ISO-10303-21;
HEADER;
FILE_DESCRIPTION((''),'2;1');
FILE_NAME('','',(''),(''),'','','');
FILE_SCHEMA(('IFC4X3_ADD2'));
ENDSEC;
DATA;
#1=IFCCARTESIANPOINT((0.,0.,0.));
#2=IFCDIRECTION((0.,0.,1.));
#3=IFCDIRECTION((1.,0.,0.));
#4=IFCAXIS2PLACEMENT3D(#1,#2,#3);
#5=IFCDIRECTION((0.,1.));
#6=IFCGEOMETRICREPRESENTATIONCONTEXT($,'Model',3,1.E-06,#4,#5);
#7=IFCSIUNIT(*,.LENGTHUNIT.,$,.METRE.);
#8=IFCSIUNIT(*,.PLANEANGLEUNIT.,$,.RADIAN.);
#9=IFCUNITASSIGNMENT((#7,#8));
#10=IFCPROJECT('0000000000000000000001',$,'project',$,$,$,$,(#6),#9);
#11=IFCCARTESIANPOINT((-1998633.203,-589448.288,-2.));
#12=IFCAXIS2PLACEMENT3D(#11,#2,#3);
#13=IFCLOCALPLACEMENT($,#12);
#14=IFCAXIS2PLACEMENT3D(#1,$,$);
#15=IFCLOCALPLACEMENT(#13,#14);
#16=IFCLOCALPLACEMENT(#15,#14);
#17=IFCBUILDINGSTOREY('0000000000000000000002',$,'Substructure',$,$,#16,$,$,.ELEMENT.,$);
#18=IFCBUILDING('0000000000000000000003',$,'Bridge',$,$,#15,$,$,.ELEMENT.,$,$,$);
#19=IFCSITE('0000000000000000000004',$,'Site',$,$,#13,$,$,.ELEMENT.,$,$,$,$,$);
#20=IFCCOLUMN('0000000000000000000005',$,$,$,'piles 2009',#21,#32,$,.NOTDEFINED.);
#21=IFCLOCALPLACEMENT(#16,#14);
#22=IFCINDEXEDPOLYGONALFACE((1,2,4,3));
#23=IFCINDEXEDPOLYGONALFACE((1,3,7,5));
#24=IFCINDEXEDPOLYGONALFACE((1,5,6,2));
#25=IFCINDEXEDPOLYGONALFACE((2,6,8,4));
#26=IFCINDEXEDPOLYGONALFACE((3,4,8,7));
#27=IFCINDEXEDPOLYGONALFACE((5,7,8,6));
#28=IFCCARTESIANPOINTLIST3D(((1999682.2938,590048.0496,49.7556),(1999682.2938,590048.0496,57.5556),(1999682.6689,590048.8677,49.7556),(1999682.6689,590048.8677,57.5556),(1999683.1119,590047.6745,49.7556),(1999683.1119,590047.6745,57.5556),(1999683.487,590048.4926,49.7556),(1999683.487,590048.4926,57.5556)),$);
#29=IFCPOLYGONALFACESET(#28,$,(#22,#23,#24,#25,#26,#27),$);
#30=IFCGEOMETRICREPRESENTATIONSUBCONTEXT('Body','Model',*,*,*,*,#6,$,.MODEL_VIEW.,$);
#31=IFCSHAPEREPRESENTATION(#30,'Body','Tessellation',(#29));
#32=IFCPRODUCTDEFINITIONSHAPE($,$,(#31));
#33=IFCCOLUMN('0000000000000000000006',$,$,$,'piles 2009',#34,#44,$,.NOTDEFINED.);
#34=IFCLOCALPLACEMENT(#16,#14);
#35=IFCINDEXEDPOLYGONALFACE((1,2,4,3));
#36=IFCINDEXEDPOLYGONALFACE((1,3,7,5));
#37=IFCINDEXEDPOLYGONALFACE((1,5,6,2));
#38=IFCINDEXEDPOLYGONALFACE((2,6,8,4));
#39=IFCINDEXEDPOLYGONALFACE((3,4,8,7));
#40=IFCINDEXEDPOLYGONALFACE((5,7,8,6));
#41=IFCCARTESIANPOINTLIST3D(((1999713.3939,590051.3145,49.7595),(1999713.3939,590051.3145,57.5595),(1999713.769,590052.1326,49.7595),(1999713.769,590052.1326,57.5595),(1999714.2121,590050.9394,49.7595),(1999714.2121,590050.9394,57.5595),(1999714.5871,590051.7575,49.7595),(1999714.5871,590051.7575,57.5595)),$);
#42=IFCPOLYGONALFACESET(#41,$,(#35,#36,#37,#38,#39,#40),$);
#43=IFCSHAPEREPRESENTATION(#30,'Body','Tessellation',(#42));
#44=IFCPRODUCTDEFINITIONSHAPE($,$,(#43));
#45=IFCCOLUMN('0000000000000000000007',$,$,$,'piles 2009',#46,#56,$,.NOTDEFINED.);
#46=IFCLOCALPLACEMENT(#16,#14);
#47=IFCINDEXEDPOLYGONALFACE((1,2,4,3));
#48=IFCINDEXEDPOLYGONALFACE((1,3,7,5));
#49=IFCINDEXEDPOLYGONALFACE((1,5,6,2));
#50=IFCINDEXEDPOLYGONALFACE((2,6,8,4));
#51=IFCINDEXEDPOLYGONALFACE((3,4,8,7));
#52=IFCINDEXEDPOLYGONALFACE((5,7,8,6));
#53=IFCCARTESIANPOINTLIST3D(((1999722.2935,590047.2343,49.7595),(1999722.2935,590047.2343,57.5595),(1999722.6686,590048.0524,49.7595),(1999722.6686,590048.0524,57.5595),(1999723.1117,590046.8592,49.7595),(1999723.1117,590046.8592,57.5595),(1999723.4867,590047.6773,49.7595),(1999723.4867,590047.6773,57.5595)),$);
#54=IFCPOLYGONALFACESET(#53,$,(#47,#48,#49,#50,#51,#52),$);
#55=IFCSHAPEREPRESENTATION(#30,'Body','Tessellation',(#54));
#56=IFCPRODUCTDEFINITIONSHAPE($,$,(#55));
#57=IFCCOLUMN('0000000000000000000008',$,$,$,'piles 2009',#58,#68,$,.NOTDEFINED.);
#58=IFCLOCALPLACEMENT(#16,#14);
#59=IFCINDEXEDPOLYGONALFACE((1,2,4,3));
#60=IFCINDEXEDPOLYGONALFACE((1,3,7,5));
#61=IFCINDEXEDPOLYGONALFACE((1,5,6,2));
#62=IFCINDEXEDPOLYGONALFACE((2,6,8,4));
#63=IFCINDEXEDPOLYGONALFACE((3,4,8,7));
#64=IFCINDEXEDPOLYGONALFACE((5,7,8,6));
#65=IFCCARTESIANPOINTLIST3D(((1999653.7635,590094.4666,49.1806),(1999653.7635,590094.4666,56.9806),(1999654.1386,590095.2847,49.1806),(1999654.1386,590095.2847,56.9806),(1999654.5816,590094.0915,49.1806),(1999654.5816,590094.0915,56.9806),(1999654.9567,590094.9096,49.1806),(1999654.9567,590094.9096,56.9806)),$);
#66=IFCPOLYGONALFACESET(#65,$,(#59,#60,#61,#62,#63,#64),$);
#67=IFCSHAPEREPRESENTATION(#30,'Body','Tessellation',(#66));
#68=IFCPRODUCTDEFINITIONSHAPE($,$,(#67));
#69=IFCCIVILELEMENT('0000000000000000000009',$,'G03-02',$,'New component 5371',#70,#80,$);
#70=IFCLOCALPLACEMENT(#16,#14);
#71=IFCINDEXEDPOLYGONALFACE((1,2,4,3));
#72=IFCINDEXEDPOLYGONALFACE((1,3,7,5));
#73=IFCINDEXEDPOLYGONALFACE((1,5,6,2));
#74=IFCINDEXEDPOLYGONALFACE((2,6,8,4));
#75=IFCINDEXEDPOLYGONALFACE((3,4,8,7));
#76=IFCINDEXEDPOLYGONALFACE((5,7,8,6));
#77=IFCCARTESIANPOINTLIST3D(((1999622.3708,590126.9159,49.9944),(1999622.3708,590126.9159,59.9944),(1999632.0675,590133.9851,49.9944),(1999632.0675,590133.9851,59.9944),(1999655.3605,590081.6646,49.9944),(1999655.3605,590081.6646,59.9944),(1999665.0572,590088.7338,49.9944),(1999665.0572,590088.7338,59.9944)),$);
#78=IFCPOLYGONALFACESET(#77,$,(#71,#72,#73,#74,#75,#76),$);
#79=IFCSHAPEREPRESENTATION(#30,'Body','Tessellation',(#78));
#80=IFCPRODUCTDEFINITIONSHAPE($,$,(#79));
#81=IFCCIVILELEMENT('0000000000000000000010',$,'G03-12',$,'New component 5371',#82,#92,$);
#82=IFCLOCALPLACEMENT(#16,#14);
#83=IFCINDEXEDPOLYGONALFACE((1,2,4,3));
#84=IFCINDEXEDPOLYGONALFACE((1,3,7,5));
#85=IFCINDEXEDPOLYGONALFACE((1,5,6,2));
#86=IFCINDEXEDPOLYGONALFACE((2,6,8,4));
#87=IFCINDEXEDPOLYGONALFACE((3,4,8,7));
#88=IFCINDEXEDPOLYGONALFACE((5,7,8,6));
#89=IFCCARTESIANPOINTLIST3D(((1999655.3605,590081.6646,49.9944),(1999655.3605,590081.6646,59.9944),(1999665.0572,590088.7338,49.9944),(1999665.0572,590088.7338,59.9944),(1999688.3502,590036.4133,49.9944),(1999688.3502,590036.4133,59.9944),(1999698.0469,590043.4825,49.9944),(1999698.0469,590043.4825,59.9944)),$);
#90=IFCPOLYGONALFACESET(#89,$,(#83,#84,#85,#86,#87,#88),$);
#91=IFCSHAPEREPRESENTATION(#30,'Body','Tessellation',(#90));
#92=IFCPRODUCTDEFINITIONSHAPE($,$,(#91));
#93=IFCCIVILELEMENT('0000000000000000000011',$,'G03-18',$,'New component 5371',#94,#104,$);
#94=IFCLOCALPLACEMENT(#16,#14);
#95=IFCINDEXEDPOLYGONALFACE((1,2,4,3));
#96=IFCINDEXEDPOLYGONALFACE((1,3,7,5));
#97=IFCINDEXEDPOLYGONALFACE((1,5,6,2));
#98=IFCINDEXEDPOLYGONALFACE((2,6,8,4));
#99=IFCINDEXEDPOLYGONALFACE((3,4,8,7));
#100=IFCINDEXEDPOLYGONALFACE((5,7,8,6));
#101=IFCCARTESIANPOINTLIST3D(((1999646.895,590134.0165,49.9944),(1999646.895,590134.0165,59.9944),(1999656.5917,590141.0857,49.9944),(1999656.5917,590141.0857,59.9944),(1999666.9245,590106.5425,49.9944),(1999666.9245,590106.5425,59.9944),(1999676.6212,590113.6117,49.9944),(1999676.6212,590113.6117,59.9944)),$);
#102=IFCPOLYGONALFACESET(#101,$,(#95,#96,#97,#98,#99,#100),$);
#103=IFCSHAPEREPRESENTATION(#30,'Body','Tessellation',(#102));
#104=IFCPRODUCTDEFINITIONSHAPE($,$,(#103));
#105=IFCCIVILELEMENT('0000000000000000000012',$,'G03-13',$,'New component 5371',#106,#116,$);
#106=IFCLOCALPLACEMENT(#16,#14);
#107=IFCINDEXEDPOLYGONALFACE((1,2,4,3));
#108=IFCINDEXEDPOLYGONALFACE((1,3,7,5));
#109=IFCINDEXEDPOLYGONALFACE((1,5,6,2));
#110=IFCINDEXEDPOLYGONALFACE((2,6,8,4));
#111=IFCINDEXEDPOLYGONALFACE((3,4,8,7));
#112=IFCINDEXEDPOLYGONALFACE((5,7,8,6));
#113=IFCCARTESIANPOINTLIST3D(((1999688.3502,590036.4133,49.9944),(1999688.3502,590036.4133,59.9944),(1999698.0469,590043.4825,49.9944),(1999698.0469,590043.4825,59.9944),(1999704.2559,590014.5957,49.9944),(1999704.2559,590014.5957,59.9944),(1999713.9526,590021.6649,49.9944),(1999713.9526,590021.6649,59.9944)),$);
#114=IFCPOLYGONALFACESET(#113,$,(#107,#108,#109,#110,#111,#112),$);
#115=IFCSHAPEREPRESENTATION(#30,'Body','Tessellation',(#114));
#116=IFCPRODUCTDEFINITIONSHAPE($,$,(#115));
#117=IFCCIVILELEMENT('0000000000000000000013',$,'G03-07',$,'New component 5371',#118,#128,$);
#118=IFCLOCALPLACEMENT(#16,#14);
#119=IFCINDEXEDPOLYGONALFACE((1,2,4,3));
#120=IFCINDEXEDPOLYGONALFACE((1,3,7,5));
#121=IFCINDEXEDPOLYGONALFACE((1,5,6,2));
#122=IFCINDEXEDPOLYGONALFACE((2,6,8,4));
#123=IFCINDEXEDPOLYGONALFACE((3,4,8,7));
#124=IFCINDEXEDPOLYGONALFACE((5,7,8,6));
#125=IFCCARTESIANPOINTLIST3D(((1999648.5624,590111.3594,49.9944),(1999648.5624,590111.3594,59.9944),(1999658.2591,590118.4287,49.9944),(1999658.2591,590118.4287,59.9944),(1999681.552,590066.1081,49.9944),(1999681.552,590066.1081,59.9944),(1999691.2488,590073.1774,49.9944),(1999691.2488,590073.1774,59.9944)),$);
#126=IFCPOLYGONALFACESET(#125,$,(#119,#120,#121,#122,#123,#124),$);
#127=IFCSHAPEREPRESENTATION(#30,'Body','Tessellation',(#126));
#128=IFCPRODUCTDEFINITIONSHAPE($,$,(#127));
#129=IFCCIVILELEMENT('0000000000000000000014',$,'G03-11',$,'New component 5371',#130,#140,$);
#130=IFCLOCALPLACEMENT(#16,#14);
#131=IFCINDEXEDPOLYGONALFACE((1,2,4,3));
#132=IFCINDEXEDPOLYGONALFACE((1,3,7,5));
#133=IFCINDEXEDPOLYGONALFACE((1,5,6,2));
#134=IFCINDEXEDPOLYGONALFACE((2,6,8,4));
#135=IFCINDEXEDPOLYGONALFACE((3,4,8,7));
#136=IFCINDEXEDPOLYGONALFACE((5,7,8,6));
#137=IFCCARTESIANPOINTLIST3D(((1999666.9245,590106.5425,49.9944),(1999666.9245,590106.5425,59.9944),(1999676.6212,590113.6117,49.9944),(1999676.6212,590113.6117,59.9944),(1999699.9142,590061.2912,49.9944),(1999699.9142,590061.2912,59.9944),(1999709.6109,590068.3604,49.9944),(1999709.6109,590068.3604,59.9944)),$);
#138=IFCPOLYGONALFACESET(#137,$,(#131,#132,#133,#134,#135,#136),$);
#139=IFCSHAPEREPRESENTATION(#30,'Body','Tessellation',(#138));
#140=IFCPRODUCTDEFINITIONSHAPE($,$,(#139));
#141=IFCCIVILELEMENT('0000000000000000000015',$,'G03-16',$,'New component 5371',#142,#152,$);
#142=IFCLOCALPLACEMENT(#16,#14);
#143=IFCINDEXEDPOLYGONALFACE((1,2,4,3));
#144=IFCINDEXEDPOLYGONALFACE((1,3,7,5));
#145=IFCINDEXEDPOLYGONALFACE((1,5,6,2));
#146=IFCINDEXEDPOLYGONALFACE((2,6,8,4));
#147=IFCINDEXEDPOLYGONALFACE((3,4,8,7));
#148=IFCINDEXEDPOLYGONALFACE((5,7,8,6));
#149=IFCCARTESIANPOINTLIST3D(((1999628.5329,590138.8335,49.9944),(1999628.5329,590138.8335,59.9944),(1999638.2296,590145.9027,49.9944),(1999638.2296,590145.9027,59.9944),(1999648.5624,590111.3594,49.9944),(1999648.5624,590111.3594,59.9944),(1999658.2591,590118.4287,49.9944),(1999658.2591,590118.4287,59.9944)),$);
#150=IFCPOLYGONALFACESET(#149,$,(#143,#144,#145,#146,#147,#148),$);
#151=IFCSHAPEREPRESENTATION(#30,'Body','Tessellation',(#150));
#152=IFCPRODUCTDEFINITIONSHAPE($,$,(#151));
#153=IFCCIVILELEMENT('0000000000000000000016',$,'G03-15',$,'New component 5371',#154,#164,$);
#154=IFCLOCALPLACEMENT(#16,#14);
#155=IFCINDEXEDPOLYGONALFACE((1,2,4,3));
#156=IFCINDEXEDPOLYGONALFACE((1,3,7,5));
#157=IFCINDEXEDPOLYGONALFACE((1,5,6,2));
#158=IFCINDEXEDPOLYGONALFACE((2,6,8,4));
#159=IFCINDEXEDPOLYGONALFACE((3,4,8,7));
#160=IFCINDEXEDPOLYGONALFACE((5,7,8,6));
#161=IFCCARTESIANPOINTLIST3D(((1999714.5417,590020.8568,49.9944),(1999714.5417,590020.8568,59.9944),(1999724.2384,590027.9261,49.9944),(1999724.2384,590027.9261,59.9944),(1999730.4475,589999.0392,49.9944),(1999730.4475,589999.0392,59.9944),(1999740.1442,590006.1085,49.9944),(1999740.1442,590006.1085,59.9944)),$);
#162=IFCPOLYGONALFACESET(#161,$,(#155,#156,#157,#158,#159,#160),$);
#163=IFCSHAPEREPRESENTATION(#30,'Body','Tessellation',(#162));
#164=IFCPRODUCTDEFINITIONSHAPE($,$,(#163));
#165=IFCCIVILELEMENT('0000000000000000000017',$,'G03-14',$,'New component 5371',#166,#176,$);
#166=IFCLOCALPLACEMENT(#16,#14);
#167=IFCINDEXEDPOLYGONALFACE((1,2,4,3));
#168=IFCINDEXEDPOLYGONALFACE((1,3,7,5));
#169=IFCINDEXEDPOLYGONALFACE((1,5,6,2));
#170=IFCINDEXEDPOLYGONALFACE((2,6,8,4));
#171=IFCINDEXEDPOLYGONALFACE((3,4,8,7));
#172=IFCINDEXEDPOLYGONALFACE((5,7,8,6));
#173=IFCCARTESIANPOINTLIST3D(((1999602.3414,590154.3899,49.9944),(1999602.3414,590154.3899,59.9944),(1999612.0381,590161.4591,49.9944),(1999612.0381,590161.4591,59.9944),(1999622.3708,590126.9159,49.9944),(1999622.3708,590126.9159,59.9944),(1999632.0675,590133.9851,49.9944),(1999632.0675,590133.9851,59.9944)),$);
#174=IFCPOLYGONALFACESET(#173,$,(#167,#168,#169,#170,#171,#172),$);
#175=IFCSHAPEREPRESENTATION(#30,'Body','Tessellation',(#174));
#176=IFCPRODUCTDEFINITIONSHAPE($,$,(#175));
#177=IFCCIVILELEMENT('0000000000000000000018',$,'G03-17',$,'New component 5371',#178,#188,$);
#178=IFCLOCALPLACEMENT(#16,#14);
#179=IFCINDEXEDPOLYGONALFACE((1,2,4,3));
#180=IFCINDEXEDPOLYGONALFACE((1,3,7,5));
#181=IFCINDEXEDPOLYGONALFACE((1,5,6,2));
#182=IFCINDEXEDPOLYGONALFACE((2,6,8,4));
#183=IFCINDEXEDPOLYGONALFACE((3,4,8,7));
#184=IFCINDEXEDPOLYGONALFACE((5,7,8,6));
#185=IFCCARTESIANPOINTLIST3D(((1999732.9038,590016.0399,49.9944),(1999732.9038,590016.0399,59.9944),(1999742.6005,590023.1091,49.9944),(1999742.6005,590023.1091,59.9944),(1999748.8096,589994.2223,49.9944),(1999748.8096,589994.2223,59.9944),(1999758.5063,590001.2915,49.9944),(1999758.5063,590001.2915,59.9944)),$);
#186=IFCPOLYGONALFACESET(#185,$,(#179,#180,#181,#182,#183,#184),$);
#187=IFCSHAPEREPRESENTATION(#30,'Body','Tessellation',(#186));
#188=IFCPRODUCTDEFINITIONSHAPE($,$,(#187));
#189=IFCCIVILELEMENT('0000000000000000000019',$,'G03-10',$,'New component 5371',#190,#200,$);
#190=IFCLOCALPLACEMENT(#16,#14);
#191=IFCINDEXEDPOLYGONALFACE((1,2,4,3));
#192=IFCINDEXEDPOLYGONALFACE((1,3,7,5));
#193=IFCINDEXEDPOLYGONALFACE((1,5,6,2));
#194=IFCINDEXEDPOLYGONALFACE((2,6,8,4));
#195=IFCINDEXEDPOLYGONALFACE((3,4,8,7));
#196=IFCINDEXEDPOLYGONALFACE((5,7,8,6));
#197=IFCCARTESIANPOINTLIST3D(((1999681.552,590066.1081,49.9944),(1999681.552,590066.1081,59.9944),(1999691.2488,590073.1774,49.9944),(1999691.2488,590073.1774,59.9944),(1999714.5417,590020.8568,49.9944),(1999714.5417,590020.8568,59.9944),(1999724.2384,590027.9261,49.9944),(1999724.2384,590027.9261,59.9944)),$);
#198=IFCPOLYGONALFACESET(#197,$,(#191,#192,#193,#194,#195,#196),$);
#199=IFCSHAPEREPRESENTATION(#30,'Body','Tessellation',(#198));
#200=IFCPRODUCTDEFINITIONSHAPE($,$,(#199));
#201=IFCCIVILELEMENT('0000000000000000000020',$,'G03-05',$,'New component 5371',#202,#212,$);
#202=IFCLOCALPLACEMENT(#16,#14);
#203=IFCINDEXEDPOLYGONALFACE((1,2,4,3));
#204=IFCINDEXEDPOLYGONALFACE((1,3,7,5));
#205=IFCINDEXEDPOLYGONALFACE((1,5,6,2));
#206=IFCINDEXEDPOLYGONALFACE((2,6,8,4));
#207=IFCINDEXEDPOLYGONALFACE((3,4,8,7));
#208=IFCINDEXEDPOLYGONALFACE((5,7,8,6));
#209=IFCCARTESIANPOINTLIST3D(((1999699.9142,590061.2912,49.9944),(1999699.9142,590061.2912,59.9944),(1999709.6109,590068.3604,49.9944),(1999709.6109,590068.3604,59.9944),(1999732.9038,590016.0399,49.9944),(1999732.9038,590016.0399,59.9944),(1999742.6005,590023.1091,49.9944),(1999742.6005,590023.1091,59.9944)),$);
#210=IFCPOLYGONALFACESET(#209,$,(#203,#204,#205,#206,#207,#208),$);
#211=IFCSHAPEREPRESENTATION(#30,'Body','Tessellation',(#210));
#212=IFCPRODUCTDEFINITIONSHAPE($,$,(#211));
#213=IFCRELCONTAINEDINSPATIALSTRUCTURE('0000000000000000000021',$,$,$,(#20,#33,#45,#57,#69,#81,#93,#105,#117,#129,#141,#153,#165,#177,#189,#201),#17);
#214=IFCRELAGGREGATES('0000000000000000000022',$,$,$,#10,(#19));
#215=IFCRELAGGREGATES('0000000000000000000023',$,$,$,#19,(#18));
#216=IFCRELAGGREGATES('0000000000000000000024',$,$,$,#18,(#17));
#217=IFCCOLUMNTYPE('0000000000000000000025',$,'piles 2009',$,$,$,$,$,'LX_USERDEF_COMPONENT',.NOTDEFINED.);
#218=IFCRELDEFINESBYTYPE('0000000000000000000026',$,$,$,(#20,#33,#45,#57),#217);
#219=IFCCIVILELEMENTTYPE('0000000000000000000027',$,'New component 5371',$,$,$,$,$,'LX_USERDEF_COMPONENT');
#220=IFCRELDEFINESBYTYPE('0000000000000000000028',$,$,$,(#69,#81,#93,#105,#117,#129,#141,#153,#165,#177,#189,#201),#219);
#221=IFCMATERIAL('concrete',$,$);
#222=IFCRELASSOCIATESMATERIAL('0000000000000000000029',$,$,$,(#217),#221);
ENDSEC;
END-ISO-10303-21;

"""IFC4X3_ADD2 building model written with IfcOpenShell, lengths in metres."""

from ifc_helpers import new_model, si_unit, direction, frame, frame_2d, origin, origin_with_axes, place, context, subcontext, project, spatial, rectangle, extrude, material, type_object, element, save


model = new_model("IFC4X3_ADD2")

# Units and contexts
model_context = context("Model", 3, precision=1e-06, world=origin_with_axes(), true_north=direction((0.0, 1.0)))
body_context = subcontext(model_context, "Body", "Model", "MODEL_VIEW")
ifc_project = project(units=[si_unit("LENGTHUNIT", "METRE"), si_unit("PLANEANGLEUNIT", "RADIAN")], contexts=[model_context])

# Site, building, storey
site_placement = place(None, frame((-1998633.203, -589448.288, -2.0), z_axis=(0.0, 0.0, 1.0), x_axis=(1.0, 0.0, 0.0)))
site = spatial("IfcSite", under=ifc_project, at=site_placement, Name="Site", CompositionType="ELEMENT")
building_placement = place(site_placement, origin())
building = spatial("IfcBuilding", under=site, at=building_placement, Name="Bridge", CompositionType="ELEMENT")
storey_placement = place(building_placement, origin())
storey = spatial("IfcBuildingStorey", under=building, at=storey_placement, Name="Substructure", CompositionType="ELEMENT")

# Columns
ifc_material = material(Name="concrete")
column_type = type_object("IfcColumnType", Name="piles 2009", ElementType="LX_USERDEF_COMPONENT", PredefinedType="NOTDEFINED", material=ifc_material)
for number, where, z_axis, x_axis in (
    (1, (1999683.1119, 590047.6745, 49.7556), (0.0, 0.0, 1.0), (0.416757, 0.909018, 0.0)),
    (2, (1999714.2121, 590050.9394, 49.7595), (0.0, 0.0, 1.0), (0.416757, 0.909018, 0.0)),
    (3, (1999723.1117, 590046.8592, 49.7595), (0.0, 0.0, 1.0), (0.416757, 0.909018, 0.0)),
    (4, (1999654.5816, 590094.0915, 49.1806), (0.0, 0.0, 1.0), (0.416757, 0.909018, 0.0)),
):
    element("IfcColumn", number, at=place(storey_placement, frame(where, z_axis=z_axis, x_axis=x_axis)), inside=storey, type_object=column_type, ObjectType="piles 2009", PredefinedType="NOTDEFINED", context=body_context, shape_type="SweptSolid", body=[
        extrude(rectangle(XDim=0.9, YDim=0.9, at=frame_2d((0.45, 0.45), x_axis=(1.0, 0.0))), origin_with_axes(), (0.0, 0.0, 1.0), 7.8),
    ])

# Civil elements
civil_element_type = type_object("IfcCivilElementType", Name="New component 5371", ElementType="LX_USERDEF_COMPONENT")
for number, where, z_axis, x_axis, name in (
    (5, (1999655.3605, 590081.6646, 49.9944), (0.0, 0.0, 1.0), (0.808059, 0.589101, 0.0), "G03-02"),
    (6, (1999688.3502, 590036.4133, 49.9944), (0.0, 0.0, 1.0), (0.808059, 0.589101, 0.0), "G03-12"),
):
    element("IfcCivilElement", number, at=place(storey_placement, frame(where, z_axis=z_axis, x_axis=x_axis)), inside=storey, type_object=civil_element_type, Name=name, ObjectType="New component 5371", context=body_context, shape_type="SweptSolid", body=[
        extrude(rectangle(XDim=12.0, YDim=56.0, at=frame_2d((6.0, 28.0), x_axis=(1.0, 0.0))), origin_with_axes(), (0.0, 0.0, 1.0), 10.0),
    ])
civil_element_1_placement = place(storey_placement, frame((1999666.9245, 590106.5425, 49.9944), z_axis=(0.0, 0.0, 1.0), x_axis=(0.808059, 0.589101, 0.0)))
element("IfcCivilElement", 7, at=civil_element_1_placement, inside=storey, type_object=civil_element_type, Name="G03-18", ObjectType="New component 5371", context=body_context, shape_type="SweptSolid", body=[
    extrude(rectangle(XDim=12.0, YDim=34.0, at=frame_2d((6.0, 17.0), x_axis=(1.0, 0.0))), origin_with_axes(), (0.0, 0.0, 1.0), 10.0),
])
civil_element_2_placement = place(storey_placement, frame((1999704.2559, 590014.5957, 49.9944), z_axis=(0.0, 0.0, 1.0), x_axis=(0.808059, 0.589101, 0.0)))
element("IfcCivilElement", 8, at=civil_element_2_placement, inside=storey, type_object=civil_element_type, Name="G03-13", ObjectType="New component 5371", context=body_context, shape_type="SweptSolid", body=[
    extrude(rectangle(XDim=12.0, YDim=27.0, at=frame_2d((6.0, 13.5), x_axis=(1.0, 0.0))), origin_with_axes(), (0.0, 0.0, 1.0), 10.0),
])
for number, where, z_axis, x_axis, name in (
    (9, (1999681.552, 590066.1081, 49.9944), (0.0, 0.0, 1.0), (0.808059, 0.589101, 0.0), "G03-07"),
    (10, (1999699.9142, 590061.2912, 49.9944), (0.0, 0.0, 1.0), (0.808059, 0.589101, 0.0), "G03-11"),
):
    element("IfcCivilElement", number, at=place(storey_placement, frame(where, z_axis=z_axis, x_axis=x_axis)), inside=storey, type_object=civil_element_type, Name=name, ObjectType="New component 5371", context=body_context, shape_type="SweptSolid", body=[
        extrude(rectangle(XDim=12.0, YDim=56.0, at=frame_2d((6.0, 28.0), x_axis=(1.0, 0.0))), origin_with_axes(), (0.0, 0.0, 1.0), 10.0),
    ])
civil_element_3_placement = place(storey_placement, frame((1999648.5624, 590111.3594, 49.9944), z_axis=(0.0, 0.0, 1.0), x_axis=(0.808059, 0.589101, 0.0)))
element("IfcCivilElement", 11, at=civil_element_3_placement, inside=storey, type_object=civil_element_type, Name="G03-16", ObjectType="New component 5371", context=body_context, shape_type="SweptSolid", body=[
    extrude(rectangle(XDim=12.0, YDim=34.0, at=frame_2d((6.0, 17.0), x_axis=(1.0, 0.0))), origin_with_axes(), (0.0, 0.0, 1.0), 10.0),
])
civil_element_4_placement = place(storey_placement, frame((1999730.4475, 589999.0392, 49.9944), z_axis=(0.0, 0.0, 1.0), x_axis=(0.808059, 0.589101, 0.0)))
element("IfcCivilElement", 12, at=civil_element_4_placement, inside=storey, type_object=civil_element_type, Name="G03-15", ObjectType="New component 5371", context=body_context, shape_type="SweptSolid", body=[
    extrude(rectangle(XDim=12.0, YDim=27.0, at=frame_2d((6.0, 13.5), x_axis=(1.0, 0.0))), origin_with_axes(), (0.0, 0.0, 1.0), 10.0),
])
civil_element_5_placement = place(storey_placement, frame((1999622.3708, 590126.9159, 49.9944), z_axis=(0.0, 0.0, 1.0), x_axis=(0.808059, 0.589101, 0.0)))
element("IfcCivilElement", 13, at=civil_element_5_placement, inside=storey, type_object=civil_element_type, Name="G03-14", ObjectType="New component 5371", context=body_context, shape_type="SweptSolid", body=[
    extrude(rectangle(XDim=12.0, YDim=34.0, at=frame_2d((6.0, 17.0), x_axis=(1.0, 0.0))), origin_with_axes(), (0.0, 0.0, 1.0), 10.0),
])
civil_element_6_placement = place(storey_placement, frame((1999748.8096, 589994.2223, 49.9944), z_axis=(0.0, 0.0, 1.0), x_axis=(0.808059, 0.589101, 0.0)))
element("IfcCivilElement", 14, at=civil_element_6_placement, inside=storey, type_object=civil_element_type, Name="G03-17", ObjectType="New component 5371", context=body_context, shape_type="SweptSolid", body=[
    extrude(rectangle(XDim=12.0, YDim=27.0, at=frame_2d((6.0, 13.5), x_axis=(1.0, 0.0))), origin_with_axes(), (0.0, 0.0, 1.0), 10.0),
])
for number, where, z_axis, x_axis, name in (
    (15, (1999714.5417, 590020.8568, 49.9944), (0.0, 0.0, 1.0), (0.808059, 0.589101, 0.0), "G03-10"),
    (16, (1999732.9038, 590016.0399, 49.9944), (0.0, 0.0, 1.0), (0.808059, 0.589101, 0.0), "G03-05"),
):
    element("IfcCivilElement", number, at=place(storey_placement, frame(where, z_axis=z_axis, x_axis=x_axis)), inside=storey, type_object=civil_element_type, Name=name, ObjectType="New component 5371", context=body_context, shape_type="SweptSolid", body=[
        extrude(rectangle(XDim=12.0, YDim=56.0, at=frame_2d((6.0, 28.0), x_axis=(1.0, 0.0))), origin_with_axes(), (0.0, 0.0, 1.0), 10.0),
    ])

save(model, "model.ifc")
